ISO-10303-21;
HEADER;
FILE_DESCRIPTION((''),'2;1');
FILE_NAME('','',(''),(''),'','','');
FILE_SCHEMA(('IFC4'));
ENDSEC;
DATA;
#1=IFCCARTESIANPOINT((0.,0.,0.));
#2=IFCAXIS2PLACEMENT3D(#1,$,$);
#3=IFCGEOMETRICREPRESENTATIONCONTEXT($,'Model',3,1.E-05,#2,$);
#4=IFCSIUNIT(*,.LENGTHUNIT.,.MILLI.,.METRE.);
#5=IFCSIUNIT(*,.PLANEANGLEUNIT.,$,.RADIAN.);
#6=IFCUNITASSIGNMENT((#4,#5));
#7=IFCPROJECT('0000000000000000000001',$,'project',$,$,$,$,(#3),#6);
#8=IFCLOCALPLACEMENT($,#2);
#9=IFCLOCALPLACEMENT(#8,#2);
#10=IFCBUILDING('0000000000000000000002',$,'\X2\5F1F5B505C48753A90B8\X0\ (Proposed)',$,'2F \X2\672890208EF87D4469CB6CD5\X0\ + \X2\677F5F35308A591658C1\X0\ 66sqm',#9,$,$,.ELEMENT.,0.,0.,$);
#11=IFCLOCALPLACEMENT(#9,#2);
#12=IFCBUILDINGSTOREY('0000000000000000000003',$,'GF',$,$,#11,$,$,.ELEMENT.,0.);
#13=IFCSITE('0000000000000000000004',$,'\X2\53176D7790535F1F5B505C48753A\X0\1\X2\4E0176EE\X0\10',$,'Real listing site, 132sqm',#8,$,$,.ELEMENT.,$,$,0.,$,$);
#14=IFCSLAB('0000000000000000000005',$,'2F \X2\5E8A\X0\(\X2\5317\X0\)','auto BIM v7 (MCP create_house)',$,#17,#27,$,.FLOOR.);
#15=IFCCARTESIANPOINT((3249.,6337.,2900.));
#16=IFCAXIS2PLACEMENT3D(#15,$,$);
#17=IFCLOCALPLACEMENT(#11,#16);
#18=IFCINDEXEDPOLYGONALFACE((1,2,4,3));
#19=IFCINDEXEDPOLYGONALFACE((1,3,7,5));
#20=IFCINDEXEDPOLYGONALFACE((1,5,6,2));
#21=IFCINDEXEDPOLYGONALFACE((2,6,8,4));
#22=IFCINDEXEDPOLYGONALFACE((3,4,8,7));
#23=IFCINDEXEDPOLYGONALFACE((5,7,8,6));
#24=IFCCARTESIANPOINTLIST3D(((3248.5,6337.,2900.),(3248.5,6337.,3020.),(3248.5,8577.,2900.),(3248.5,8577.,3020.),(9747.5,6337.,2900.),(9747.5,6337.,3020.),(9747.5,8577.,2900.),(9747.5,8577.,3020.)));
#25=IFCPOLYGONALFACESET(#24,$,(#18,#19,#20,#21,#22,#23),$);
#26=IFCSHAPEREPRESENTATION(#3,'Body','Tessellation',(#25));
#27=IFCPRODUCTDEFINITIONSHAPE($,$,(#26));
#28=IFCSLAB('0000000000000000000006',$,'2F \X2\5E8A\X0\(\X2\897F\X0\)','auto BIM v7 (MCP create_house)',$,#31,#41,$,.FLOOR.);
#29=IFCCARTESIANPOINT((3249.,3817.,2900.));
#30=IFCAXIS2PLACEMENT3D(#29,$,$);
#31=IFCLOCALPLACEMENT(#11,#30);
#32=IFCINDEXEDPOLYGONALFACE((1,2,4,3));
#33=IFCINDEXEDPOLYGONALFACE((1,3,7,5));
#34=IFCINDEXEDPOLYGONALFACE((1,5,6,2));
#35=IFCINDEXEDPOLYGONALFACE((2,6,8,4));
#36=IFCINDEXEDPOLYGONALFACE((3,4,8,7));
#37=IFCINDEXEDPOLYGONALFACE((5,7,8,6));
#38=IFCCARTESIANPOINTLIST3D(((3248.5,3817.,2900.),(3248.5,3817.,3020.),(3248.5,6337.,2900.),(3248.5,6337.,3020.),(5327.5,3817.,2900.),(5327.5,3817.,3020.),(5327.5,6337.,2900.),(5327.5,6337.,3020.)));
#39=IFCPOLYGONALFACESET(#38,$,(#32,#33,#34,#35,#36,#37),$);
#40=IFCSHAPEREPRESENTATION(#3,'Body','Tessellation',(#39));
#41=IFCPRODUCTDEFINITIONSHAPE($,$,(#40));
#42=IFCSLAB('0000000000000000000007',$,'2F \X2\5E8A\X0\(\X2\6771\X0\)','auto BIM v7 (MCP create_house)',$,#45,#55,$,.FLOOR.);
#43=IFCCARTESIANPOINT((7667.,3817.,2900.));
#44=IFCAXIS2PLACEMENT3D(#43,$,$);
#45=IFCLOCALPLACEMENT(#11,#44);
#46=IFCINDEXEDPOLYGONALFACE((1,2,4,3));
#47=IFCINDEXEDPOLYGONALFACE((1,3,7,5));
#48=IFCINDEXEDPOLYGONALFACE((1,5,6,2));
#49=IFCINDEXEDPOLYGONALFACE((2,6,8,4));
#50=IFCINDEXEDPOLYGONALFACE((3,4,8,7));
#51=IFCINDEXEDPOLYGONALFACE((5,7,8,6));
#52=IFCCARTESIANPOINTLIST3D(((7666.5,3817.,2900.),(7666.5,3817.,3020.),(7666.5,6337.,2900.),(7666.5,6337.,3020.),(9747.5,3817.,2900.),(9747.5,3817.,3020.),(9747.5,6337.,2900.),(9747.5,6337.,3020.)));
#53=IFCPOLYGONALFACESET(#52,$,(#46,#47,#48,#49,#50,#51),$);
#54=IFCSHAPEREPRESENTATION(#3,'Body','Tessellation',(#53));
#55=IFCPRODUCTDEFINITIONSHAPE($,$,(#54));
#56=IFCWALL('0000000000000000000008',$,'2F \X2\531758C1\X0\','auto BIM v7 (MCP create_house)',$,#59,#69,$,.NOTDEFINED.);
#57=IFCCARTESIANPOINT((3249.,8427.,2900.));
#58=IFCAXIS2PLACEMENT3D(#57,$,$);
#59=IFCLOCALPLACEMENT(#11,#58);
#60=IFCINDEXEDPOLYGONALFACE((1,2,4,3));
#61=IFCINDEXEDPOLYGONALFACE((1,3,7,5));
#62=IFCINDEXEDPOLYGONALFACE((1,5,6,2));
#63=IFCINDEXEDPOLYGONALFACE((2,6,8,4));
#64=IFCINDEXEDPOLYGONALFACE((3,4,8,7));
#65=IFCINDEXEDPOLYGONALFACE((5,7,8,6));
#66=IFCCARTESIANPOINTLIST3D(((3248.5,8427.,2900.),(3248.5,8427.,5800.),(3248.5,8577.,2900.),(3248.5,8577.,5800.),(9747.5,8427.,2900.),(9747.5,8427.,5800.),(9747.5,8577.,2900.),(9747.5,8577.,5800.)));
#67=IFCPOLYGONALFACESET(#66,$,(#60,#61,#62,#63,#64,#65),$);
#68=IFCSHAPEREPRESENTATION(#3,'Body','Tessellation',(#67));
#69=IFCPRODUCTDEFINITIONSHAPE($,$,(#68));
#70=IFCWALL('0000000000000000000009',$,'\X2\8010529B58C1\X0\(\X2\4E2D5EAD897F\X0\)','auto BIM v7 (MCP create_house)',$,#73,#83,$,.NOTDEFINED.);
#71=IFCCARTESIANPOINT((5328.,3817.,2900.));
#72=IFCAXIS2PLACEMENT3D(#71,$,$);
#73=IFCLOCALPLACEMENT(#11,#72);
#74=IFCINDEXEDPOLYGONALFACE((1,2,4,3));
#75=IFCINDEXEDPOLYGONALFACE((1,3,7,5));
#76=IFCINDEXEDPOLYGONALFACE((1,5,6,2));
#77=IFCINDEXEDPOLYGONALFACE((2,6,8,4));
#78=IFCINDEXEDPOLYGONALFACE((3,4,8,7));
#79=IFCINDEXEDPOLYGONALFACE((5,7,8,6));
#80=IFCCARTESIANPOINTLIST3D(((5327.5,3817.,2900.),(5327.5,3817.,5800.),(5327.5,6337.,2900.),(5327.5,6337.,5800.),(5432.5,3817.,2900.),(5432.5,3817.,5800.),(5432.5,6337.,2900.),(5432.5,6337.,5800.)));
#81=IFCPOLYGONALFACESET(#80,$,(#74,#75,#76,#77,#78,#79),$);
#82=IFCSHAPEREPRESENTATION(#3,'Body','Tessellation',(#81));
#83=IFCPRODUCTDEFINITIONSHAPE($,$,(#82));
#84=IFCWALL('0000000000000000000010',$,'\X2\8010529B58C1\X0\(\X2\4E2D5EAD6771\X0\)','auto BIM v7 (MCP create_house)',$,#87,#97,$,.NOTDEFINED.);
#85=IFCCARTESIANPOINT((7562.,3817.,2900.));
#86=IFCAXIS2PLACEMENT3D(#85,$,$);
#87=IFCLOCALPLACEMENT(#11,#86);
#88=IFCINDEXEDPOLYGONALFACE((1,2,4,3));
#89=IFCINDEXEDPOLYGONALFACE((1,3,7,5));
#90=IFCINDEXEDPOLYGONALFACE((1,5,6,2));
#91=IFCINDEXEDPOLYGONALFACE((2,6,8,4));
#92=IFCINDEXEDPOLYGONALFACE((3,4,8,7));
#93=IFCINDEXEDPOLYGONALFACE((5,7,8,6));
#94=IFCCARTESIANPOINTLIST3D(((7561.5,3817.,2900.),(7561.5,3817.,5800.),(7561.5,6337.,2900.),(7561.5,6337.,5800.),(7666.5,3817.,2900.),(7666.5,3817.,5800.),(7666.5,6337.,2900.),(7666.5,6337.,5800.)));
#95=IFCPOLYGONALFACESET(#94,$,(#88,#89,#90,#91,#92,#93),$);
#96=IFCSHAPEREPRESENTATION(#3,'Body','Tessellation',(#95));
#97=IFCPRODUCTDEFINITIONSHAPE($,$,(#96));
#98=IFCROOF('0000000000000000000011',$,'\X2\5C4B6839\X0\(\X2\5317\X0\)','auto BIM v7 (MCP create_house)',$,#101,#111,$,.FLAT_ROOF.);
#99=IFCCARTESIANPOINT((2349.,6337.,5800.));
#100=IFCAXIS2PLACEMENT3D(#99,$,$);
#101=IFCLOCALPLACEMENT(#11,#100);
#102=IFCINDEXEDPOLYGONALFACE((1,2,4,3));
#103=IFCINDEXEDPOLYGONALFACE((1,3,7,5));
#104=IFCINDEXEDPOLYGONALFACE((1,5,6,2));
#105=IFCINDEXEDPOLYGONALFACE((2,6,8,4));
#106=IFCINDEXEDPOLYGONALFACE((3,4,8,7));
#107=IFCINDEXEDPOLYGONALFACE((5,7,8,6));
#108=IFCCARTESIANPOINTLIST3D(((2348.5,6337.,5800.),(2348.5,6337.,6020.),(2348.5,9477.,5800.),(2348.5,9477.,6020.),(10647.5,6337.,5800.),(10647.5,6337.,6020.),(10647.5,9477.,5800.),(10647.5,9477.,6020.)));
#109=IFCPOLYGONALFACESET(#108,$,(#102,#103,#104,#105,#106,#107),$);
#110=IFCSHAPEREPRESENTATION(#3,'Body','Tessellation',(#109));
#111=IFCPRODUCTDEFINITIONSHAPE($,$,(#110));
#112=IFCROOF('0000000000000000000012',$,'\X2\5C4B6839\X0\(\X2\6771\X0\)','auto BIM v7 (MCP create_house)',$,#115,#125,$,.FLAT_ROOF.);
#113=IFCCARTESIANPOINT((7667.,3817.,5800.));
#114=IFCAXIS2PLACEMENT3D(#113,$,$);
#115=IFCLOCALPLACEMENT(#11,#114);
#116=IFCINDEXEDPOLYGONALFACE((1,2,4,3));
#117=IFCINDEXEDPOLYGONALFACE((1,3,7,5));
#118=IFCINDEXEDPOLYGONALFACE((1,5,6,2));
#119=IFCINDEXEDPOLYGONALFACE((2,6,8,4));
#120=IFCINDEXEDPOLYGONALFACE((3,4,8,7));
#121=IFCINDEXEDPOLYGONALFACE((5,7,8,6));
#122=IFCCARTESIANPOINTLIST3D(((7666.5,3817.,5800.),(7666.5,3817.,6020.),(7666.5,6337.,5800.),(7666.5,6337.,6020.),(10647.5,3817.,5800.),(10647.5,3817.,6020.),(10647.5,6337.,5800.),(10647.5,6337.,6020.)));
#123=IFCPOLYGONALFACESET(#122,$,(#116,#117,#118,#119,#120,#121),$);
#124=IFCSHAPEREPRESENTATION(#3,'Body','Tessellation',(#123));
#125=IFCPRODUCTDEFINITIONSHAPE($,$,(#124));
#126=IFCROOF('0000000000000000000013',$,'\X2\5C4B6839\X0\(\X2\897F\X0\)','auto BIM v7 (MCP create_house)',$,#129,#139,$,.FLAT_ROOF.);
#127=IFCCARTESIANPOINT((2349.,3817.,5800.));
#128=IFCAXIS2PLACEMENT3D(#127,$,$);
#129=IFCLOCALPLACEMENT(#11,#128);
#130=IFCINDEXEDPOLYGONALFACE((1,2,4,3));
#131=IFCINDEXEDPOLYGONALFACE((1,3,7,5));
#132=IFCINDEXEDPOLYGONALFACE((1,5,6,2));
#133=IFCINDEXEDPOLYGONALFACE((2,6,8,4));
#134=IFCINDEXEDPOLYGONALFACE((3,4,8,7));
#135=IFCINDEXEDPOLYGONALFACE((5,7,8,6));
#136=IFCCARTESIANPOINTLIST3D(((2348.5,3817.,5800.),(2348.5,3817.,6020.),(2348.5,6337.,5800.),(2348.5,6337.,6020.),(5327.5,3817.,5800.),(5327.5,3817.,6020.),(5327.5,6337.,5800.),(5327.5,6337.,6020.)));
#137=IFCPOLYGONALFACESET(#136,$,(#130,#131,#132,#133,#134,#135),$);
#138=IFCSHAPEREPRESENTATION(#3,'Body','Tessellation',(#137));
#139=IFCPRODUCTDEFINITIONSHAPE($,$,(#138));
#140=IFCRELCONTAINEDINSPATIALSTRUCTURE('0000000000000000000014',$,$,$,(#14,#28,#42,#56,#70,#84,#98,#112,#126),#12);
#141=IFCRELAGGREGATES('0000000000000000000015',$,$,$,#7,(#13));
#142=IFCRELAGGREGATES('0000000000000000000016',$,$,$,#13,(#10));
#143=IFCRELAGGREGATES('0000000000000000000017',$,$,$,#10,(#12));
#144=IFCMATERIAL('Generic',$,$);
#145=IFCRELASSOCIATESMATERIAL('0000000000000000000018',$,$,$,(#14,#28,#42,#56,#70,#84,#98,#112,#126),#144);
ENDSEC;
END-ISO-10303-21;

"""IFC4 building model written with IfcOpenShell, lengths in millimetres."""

from ifc_helpers import new_model, si_unit, frame, frame_2d, origin, place, context, project, spatial, rectangle, extrude, material, element, save


model = new_model("IFC4")

# Units and contexts
model_context = context("Model", 3, precision=1e-05, world=origin())
ifc_project = project(units=[si_unit("LENGTHUNIT", "METRE", prefix="MILLI"), si_unit("PLANEANGLEUNIT", "RADIAN")], contexts=[model_context])

# Site, building, storey
site_placement = place(None, origin())
site = spatial("IfcSite", under=ifc_project, at=site_placement, Name="北海道弟子屈町1丁目10", ObjectType="Real listing site, 132sqm", CompositionType="ELEMENT", RefElevation=0.0)
building_placement = place(site_placement, origin())
building = spatial("IfcBuilding", under=site, at=building_placement, Name="弟子屈町邸 (Proposed)", ObjectType="2F 木造軸組構法 + 板張り外壁 66sqm", CompositionType="ELEMENT", ElevationOfRefHeight=0.0, ElevationOfTerrain=0.0)
storey_placement = place(building_placement, origin())
storey = spatial("IfcBuildingStorey", under=building, at=storey_placement, Name="GF", CompositionType="ELEMENT", Elevation=0.0)

# Slabs
ifc_material = material(Name="Generic")
slab_1_placement = place(storey_placement, frame((3249.0, 6337.0, 2900.0)))
element("IfcSlab", 1, at=slab_1_placement, inside=storey, material=ifc_material, Name="2F 床(北)", Description="auto BIM v7 (MCP create_house)", PredefinedType="FLOOR", context=model_context, shape_type="SweptSolid", body=[
    extrude(rectangle(XDim=6499.0, YDim=2240.0, at=frame_2d((3249.0, 1120.0))), frame((3249.0, 6337.0, 2900.0)), (0.0, 0.0, 1.0), 120.0),
])
slab_2_placement = place(storey_placement, frame((3249.0, 3817.0, 2900.0)))
element("IfcSlab", 2, at=slab_2_placement, inside=storey, material=ifc_material, Name="2F 床(西)", Description="auto BIM v7 (MCP create_house)", PredefinedType="FLOOR", context=model_context, shape_type="SweptSolid", body=[
    extrude(rectangle(XDim=2079.0, YDim=2520.0, at=frame_2d((1039.0, 1260.0))), frame((3249.0, 3817.0, 2900.0)), (0.0, 0.0, 1.0), 120.0),
])
slab_3_placement = place(storey_placement, frame((7667.0, 3817.0, 2900.0)))
element("IfcSlab", 3, at=slab_3_placement, inside=storey, material=ifc_material, Name="2F 床(東)", Description="auto BIM v7 (MCP create_house)", PredefinedType="FLOOR", context=model_context, shape_type="SweptSolid", body=[
    extrude(rectangle(XDim=2081.0, YDim=2520.0, at=frame_2d((1040.0, 1260.0))), frame((7667.0, 3817.0, 2900.0)), (0.0, 0.0, 1.0), 120.0),
])

# Wall
wall_1_placement = place(storey_placement, frame((3249.0, 8427.0, 2900.0)))
element("IfcWall", 4, at=wall_1_placement, inside=storey, material=ifc_material, Name="2F 北壁", Description="auto BIM v7 (MCP create_house)", PredefinedType="NOTDEFINED", context=model_context, shape_type="SweptSolid", body=[
    extrude(rectangle(XDim=6499.0, YDim=150.0, at=frame_2d((3249.0, 75.0))), frame((3249.0, 8427.0, 2900.0)), (0.0, 0.0, 1.0), 2900.0),
])

# Walls
wall_2_placement = place(storey_placement, frame((5328.0, 3817.0, 2900.0)))
element("IfcWall", 5, at=wall_2_placement, inside=storey, material=ifc_material, Name="耐力壁(中庭西)", Description="auto BIM v7 (MCP create_house)", PredefinedType="NOTDEFINED", context=model_context, shape_type="SweptSolid", body=[
    extrude(rectangle(XDim=105.0, YDim=2520.0, at=frame_2d((52.0, 1260.0))), frame((5328.0, 3817.0, 2900.0)), (0.0, 0.0, 1.0), 2900.0),
])
wall_3_placement = place(storey_placement, frame((7562.0, 3817.0, 2900.0)))
element("IfcWall", 6, at=wall_3_placement, inside=storey, material=ifc_material, Name="耐力壁(中庭東)", Description="auto BIM v7 (MCP create_house)", PredefinedType="NOTDEFINED", context=model_context, shape_type="SweptSolid", body=[
    extrude(rectangle(XDim=105.0, YDim=2520.0, at=frame_2d((52.0, 1260.0))), frame((7562.0, 3817.0, 2900.0)), (0.0, 0.0, 1.0), 2900.0),
])

# Roofs
roof_1_placement = place(storey_placement, frame((2349.0, 6337.0, 5800.0)))
element("IfcRoof", 7, at=roof_1_placement, inside=storey, material=ifc_material, Name="屋根(北)", Description="auto BIM v7 (MCP create_house)", PredefinedType="FLAT_ROOF", context=model_context, shape_type="SweptSolid", body=[
    extrude(rectangle(XDim=8299.0, YDim=3140.0, at=frame_2d((4149.0, 1570.0))), frame((2349.0, 6337.0, 5800.0)), (0.0, 0.0, 1.0), 220.0),
])
roof_2_placement = place(storey_placement, frame((7667.0, 3817.0, 5800.0)))
element("IfcRoof", 8, at=roof_2_placement, inside=storey, material=ifc_material, Name="屋根(東)", Description="auto BIM v7 (MCP create_house)", PredefinedType="FLAT_ROOF", context=model_context, shape_type="SweptSolid", body=[
    extrude(rectangle(XDim=2981.0, YDim=2520.0, at=frame_2d((1490.0, 1260.0))), frame((7667.0, 3817.0, 5800.0)), (0.0, 0.0, 1.0), 220.0),
])
roof_3_placement = place(storey_placement, frame((2349.0, 3817.0, 5800.0)))
element("IfcRoof", 9, at=roof_3_placement, inside=storey, material=ifc_material, Name="屋根(西)", Description="auto BIM v7 (MCP create_house)", PredefinedType="FLAT_ROOF", context=model_context, shape_type="SweptSolid", body=[
    extrude(rectangle(XDim=2979.0, YDim=2520.0, at=frame_2d((1489.0, 1260.0))), frame((2349.0, 3817.0, 5800.0)), (0.0, 0.0, 1.0), 220.0),
])

save(model, "model.ifc")
